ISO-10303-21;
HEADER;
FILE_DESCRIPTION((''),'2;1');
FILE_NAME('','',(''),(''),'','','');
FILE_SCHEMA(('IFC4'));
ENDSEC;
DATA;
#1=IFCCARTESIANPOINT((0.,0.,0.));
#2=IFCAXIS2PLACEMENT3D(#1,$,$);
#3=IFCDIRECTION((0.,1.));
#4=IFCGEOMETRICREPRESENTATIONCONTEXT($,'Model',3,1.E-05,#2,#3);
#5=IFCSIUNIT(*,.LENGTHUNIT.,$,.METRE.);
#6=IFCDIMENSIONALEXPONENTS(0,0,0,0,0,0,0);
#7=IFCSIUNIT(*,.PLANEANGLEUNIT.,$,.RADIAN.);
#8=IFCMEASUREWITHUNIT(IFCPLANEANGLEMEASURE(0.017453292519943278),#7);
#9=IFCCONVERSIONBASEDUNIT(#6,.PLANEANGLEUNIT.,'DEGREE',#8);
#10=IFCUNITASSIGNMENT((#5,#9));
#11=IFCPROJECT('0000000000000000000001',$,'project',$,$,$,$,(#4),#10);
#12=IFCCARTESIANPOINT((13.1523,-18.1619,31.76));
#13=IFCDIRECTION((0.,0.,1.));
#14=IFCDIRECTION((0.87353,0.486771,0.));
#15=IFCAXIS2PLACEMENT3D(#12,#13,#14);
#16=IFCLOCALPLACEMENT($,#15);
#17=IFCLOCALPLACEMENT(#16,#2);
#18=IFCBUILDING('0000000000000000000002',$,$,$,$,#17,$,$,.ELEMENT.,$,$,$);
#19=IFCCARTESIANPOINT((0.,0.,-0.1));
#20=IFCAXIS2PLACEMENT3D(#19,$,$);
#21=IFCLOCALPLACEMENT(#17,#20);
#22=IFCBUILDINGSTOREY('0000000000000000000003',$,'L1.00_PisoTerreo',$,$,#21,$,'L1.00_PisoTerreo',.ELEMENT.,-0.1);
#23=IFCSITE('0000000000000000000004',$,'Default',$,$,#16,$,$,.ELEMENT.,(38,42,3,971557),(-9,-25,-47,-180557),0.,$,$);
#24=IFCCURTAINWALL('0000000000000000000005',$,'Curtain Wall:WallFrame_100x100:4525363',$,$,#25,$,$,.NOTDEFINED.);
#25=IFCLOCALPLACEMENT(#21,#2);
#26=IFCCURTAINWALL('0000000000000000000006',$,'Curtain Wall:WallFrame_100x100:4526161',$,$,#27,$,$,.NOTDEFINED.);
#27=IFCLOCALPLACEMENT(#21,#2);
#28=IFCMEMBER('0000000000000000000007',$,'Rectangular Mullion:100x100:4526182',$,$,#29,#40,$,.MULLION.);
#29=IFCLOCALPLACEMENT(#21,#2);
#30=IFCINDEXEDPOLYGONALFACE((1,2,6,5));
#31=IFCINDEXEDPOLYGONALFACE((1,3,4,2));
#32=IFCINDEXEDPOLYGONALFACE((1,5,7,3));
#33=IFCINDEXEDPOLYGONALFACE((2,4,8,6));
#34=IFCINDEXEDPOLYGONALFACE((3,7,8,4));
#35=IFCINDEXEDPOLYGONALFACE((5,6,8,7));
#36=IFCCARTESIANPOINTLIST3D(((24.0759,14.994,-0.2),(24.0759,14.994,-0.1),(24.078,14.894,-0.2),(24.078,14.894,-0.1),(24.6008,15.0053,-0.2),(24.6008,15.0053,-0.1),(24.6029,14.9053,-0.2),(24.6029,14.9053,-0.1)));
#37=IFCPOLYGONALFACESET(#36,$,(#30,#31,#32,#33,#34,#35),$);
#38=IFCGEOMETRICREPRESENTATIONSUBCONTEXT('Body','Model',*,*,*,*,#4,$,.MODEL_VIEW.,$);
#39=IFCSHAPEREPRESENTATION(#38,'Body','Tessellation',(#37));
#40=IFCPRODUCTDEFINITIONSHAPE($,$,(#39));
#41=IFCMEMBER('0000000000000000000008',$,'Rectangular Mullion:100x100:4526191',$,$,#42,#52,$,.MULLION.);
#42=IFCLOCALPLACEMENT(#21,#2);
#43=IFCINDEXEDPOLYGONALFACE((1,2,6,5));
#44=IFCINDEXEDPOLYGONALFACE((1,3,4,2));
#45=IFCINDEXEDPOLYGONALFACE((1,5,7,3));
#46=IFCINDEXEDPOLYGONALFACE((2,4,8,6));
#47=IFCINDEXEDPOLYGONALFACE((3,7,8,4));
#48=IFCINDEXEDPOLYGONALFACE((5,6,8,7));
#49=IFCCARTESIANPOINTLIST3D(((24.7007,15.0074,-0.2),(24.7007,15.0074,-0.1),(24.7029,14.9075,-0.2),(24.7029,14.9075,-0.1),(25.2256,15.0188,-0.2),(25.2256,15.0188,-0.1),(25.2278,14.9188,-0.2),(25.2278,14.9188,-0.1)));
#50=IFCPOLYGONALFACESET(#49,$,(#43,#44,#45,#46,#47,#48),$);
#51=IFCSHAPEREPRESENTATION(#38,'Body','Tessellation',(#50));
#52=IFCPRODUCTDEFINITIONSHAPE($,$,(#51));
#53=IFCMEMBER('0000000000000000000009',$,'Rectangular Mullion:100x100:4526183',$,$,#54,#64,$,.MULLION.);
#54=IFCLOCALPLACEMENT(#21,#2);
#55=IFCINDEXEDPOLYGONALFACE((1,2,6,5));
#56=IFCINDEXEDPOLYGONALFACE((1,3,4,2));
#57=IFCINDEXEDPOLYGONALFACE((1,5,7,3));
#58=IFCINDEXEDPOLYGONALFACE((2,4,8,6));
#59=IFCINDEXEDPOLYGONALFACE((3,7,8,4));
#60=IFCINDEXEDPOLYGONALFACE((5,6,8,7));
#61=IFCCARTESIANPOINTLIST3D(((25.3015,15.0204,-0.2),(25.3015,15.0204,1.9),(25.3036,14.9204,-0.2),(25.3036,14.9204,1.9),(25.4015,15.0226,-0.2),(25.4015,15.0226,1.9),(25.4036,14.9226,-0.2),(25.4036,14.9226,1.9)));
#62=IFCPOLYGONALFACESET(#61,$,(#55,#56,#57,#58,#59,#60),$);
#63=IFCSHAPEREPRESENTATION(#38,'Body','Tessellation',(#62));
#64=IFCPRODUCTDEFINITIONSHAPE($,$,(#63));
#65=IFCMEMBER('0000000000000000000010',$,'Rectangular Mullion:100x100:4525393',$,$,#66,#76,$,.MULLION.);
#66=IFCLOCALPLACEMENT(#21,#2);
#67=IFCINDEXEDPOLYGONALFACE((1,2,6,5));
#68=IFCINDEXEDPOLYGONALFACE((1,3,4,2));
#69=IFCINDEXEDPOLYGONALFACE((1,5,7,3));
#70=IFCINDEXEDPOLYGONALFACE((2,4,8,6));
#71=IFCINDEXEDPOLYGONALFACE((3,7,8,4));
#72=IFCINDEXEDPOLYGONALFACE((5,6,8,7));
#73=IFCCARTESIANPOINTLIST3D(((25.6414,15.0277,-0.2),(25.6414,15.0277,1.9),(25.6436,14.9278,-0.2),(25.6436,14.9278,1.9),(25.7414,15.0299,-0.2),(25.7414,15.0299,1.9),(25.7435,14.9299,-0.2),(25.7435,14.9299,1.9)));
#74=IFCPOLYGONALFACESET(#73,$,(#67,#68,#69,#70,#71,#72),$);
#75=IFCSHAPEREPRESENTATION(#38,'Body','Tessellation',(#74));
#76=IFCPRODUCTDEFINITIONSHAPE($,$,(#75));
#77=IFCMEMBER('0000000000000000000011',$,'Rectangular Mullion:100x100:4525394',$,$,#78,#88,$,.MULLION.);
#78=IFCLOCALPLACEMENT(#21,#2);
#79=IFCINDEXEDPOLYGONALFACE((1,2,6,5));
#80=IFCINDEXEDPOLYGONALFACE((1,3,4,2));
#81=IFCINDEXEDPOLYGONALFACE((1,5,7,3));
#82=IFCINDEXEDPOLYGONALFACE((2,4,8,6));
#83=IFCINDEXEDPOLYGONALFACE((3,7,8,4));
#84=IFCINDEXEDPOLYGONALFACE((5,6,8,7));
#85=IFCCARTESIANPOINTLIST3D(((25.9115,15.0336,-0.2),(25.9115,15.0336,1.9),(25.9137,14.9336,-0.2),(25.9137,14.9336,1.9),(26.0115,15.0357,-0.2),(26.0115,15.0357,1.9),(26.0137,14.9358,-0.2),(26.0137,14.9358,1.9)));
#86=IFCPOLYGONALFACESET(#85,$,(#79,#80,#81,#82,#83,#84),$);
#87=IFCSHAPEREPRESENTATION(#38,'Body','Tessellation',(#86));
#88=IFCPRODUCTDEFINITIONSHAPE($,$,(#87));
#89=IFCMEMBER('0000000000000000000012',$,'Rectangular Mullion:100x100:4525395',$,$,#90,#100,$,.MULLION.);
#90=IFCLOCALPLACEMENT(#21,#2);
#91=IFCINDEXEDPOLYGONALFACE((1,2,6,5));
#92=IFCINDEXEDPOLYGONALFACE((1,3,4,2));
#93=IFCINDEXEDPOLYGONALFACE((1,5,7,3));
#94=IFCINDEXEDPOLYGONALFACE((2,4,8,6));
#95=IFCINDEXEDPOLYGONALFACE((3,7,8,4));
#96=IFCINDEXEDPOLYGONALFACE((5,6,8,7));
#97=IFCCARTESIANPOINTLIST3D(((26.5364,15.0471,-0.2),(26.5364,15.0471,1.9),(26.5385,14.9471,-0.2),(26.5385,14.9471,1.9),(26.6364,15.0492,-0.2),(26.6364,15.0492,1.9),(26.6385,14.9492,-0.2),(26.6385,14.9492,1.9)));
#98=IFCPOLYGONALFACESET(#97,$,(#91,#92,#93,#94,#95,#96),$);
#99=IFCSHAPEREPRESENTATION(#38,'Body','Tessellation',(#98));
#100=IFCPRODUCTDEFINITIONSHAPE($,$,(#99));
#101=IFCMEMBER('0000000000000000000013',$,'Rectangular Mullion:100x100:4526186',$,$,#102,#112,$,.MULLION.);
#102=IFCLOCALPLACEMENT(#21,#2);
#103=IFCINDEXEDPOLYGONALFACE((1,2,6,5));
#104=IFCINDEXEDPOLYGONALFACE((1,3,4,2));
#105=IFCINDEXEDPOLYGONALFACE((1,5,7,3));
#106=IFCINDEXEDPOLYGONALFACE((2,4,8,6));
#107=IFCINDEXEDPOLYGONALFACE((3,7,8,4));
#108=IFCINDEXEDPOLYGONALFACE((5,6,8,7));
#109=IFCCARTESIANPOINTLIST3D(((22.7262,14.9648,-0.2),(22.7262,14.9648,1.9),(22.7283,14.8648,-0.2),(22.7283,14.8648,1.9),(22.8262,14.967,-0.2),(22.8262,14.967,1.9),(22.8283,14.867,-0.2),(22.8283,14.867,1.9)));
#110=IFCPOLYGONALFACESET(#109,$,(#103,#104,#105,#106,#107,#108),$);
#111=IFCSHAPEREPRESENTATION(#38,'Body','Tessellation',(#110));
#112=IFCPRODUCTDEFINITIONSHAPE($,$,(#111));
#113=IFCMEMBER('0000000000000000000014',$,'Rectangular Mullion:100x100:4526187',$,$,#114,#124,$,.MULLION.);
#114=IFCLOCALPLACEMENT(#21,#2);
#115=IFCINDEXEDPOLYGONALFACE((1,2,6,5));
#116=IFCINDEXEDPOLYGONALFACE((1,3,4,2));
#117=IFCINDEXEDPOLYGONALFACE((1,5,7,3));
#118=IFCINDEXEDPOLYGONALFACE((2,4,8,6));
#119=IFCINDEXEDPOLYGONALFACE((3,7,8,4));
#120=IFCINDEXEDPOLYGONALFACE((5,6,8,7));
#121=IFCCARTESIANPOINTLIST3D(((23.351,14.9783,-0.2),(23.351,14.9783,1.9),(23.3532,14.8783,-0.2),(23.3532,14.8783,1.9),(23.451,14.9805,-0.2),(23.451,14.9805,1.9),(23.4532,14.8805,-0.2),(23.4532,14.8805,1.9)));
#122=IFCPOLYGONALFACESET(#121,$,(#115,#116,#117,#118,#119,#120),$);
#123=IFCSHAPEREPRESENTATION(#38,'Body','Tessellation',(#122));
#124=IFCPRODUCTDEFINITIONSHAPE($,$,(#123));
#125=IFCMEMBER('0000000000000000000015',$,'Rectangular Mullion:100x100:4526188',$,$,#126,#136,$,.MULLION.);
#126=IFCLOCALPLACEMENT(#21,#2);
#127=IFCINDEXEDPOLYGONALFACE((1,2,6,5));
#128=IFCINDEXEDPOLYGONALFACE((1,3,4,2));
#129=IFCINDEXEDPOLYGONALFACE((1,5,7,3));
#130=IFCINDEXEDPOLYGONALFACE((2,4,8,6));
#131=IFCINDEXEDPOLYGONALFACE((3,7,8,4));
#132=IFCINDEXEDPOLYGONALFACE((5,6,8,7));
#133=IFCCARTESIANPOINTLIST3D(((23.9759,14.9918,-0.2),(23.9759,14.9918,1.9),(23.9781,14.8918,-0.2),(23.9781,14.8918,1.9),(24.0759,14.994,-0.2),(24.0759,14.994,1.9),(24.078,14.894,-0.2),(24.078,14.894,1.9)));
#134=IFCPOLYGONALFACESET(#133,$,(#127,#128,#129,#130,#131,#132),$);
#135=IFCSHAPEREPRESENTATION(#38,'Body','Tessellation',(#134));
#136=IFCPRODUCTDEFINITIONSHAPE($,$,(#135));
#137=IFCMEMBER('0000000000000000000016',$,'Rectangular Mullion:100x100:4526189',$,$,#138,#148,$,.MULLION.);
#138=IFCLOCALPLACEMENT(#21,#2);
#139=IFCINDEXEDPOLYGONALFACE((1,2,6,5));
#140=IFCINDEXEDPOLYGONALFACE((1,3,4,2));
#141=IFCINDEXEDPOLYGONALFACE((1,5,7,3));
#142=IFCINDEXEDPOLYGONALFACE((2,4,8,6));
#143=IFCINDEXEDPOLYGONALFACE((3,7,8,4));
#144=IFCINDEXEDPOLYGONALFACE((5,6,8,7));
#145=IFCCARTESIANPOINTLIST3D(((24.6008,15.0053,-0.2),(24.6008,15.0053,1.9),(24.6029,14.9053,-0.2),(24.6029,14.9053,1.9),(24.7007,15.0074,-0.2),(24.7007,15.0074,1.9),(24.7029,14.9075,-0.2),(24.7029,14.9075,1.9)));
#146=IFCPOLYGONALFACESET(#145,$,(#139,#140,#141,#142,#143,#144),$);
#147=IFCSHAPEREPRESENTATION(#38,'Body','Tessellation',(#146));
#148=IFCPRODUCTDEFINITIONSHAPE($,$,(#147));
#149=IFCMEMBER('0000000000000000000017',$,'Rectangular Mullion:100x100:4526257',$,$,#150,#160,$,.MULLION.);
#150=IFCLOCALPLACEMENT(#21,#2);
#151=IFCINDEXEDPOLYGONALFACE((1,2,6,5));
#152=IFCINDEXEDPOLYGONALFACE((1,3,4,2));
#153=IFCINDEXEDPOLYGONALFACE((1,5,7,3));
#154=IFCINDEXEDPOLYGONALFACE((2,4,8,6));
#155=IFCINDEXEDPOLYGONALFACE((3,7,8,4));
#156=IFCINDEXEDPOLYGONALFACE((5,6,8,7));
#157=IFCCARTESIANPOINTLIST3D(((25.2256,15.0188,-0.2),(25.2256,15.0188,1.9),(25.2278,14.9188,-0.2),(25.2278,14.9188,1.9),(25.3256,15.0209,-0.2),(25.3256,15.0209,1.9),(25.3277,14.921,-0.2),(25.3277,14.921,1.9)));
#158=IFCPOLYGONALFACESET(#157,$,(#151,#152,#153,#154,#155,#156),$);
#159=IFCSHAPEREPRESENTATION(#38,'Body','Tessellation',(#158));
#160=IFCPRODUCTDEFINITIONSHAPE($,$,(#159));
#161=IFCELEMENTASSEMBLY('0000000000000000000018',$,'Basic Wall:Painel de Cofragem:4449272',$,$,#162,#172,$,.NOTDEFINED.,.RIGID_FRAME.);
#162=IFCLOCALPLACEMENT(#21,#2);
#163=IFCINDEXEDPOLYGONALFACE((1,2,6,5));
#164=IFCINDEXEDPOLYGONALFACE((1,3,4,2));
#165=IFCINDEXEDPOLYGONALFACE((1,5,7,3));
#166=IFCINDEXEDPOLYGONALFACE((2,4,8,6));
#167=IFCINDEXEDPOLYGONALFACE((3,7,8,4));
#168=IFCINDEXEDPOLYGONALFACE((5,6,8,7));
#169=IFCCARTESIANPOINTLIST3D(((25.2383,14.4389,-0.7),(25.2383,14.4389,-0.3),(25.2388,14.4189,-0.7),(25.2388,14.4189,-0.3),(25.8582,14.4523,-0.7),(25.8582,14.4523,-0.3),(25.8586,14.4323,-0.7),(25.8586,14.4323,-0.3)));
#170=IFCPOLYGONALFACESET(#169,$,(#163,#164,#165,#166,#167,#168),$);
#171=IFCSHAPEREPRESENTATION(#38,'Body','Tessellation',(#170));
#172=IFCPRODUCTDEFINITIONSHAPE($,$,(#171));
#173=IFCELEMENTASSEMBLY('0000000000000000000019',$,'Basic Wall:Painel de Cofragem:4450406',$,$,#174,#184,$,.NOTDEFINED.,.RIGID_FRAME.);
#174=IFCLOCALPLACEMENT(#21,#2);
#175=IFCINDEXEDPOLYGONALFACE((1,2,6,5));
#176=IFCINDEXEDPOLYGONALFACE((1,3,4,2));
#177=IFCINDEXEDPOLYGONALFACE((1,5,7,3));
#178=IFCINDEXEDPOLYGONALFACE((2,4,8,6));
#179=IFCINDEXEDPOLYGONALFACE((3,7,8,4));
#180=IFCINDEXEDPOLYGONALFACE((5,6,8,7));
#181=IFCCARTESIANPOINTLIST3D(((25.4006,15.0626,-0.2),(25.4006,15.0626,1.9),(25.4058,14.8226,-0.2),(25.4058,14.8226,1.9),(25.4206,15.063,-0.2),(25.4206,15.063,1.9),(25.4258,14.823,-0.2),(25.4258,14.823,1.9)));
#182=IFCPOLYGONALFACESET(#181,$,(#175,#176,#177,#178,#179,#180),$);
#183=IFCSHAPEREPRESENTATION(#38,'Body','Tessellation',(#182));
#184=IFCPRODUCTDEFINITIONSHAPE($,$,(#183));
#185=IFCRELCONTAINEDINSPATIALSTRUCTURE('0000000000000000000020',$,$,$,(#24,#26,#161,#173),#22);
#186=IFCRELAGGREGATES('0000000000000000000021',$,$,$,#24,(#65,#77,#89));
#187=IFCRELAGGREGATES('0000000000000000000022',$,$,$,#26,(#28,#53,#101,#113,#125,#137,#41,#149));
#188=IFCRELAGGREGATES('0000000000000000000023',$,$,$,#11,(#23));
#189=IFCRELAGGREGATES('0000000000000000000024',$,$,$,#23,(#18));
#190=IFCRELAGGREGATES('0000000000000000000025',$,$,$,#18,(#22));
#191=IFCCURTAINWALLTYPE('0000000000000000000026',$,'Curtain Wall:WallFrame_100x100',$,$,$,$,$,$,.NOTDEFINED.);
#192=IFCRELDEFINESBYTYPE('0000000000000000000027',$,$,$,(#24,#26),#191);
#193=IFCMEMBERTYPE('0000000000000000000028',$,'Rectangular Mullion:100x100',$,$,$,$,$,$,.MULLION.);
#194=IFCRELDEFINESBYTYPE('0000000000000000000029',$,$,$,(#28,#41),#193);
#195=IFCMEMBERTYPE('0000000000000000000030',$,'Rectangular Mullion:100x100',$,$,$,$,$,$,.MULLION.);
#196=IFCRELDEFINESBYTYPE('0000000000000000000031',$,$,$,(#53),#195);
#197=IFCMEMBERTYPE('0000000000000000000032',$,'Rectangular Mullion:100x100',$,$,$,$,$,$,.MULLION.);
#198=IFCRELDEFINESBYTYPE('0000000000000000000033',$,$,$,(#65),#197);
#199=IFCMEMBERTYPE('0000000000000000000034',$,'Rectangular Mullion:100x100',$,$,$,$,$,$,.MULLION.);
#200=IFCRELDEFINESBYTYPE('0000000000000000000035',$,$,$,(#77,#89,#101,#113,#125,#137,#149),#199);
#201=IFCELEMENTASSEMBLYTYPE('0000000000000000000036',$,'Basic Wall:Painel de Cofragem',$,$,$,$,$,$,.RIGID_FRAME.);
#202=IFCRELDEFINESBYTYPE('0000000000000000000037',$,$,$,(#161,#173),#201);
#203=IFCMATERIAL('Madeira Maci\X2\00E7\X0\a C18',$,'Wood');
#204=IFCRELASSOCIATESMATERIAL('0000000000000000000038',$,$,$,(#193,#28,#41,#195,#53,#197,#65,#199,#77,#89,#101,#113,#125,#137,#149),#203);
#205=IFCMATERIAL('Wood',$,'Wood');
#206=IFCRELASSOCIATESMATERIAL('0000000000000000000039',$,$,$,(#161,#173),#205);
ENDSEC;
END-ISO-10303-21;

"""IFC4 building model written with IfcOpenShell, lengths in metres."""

from ifc_helpers import new_model, entity, si_unit, converted_unit, direction, frame, origin, place, context, subcontext, project, spatial, indexed_curve, outline, extrude, source, transform, mapped, material, type_object, type_shapes, element, aggregate, save


model = new_model("IFC4")

# Units and contexts
model_context = context("Model", 3, precision=1e-05, world=origin(), true_north=direction((0.0, 1.0)))
body_context = subcontext(model_context, "Body", "Model", "MODEL_VIEW")
ifc_project = project(units=[si_unit("LENGTHUNIT", "METRE"), converted_unit("PLANEANGLEUNIT", "DEGREE", entity("IfcPlaneAngleMeasure", 0.017453292519943278), si_unit("PLANEANGLEUNIT", "RADIAN"), dimensions=[0, 0, 0, 0, 0, 0, 0])], contexts=[model_context])

# Site, building, storey
site_placement = place(None, frame((13.1523, -18.1619, 31.76), z_axis=(0.0, 0.0, 1.0), x_axis=(0.87353, 0.486771, 0.0)))
site = spatial("IfcSite", under=ifc_project, at=site_placement, Name="Default", CompositionType="ELEMENT", RefLatitude=(38, 42, 3, 971557), RefLongitude=(-9, -25, -47, -180557), RefElevation=0.0)
building_placement = place(site_placement, origin())
building = spatial("IfcBuilding", under=site, at=building_placement, CompositionType="ELEMENT")
storey_placement = place(building_placement, frame((0.0, 0.0, -0.1)))
storey = spatial("IfcBuildingStorey", under=building, at=storey_placement, Name="L1.00_PisoTerreo", LongName="L1.00_PisoTerreo", CompositionType="ELEMENT", Elevation=-0.1)

# Curtain walls
curtain_wall_type = type_object("IfcCurtainWallType", Name="Curtain Wall:WallFrame_100x100", PredefinedType="NOTDEFINED")
curtain_wall_1_placement = place(storey_placement, frame((0.0, 0.0, 0.1)))
curtain_wall_1 = element("IfcCurtainWall", 1, at=curtain_wall_1_placement, inside=storey, type_object=curtain_wall_type, Name="Curtain Wall:WallFrame_100x100:4525363", PredefinedType="NOTDEFINED")
ifc_material_1 = material(Name="Madeira Maciça C18", Category="Wood")
curtain_wall_2_placement = place(storey_placement, frame((0.0, 0.0, 0.1)))
curtain_wall_2 = element("IfcCurtainWall", 2, at=curtain_wall_2_placement, inside=storey, type_object=curtain_wall_type, Name="Curtain Wall:WallFrame_100x100:4526161", PredefinedType="NOTDEFINED")

# Members
member_type_1 = type_object("IfcMemberType", Name="Rectangular Mullion:100x100", PredefinedType="MULLION", material=ifc_material_1)
shared_shape_1 = source(origin(), body_context, "Body", "SweptSolid", [
    extrude(outline(indexed_curve([(-0.05, -0.05), (0.05, -0.05), (0.05, 0.05), (-0.05, 0.05), (-0.05, -0.05)], self_intersect=False)), frame((-0.05, 0.0, -0.525), z_axis=(0.0, 0.0, 1.0), x_axis=(0.0, -1.0, 0.0)), (0.0, 0.0, 1.0), 0.525),
])
type_shapes(member_type_1, [shared_shape_1])
member_1_placement = place(curtain_wall_2_placement, frame((24.077, 14.944, -0.3), z_axis=(-0.999767, -0.021581, 0.0), x_axis=(0.0, 0.0, -1.0)))
member_1 = element("IfcMember", 3, at=member_1_placement, type_object=member_type_1, material=ifc_material_1, Name="Rectangular Mullion:100x100:4526182", PredefinedType="MULLION", context=body_context, shape_type="MappedRepresentation", body=[
    mapped(shared_shape_1, transform((0.0, 0.0, 0.0), scale=1.0)),
])
member_2_placement = place(curtain_wall_2_placement, frame((24.7018, 14.9575, -0.3), z_axis=(-0.999767, -0.021581, 0.0), x_axis=(0.0, 0.0, -1.0)))
member_2 = element("IfcMember", 4, at=member_2_placement, type_object=member_type_1, material=ifc_material_1, Name="Rectangular Mullion:100x100:4526191", PredefinedType="MULLION", context=body_context, shape_type="MappedRepresentation", body=[
    mapped(shared_shape_1, transform((0.0, 0.0, 0.0), scale=1.0)),
])
member_type_2 = type_object("IfcMemberType", Name="Rectangular Mullion:100x100", PredefinedType="MULLION", material=ifc_material_1)
shared_shape_2 = source(origin(), body_context, "Body", "SweptSolid", [
    extrude(outline(indexed_curve([(-0.05, -0.05), (0.05, -0.05), (0.05, 0.05), (-0.05, 0.05), (-0.05, -0.05)], self_intersect=False)), frame((-0.05, 0.0, -2.1), z_axis=(0.0, 0.0, 1.0), x_axis=(-1.0, 0.0, 0.0)), (0.0, 0.0, 1.0), 2.1),
])
type_shapes(member_type_2, [shared_shape_2])
member_3_placement = place(curtain_wall_2_placement, frame((25.4025, 14.9726, -0.3), z_axis=(0.0, 0.0, -1.0), x_axis=(0.999767, 0.021581, 0.0)))
member_3 = element("IfcMember", 5, at=member_3_placement, type_object=member_type_2, material=ifc_material_1, Name="Rectangular Mullion:100x100:4526183", PredefinedType="MULLION", context=body_context, shape_type="MappedRepresentation", body=[
    mapped(shared_shape_2, transform((0.0, 0.0, 0.0), scale=1.0)),
])
member_type_3 = type_object("IfcMemberType", Name="Rectangular Mullion:100x100", PredefinedType="MULLION", material=ifc_material_1)
shared_shape_3 = source(origin(), body_context, "Body", "SweptSolid", [
    extrude(outline(indexed_curve([(-0.05, -0.05), (0.05, -0.05), (0.05, 0.05), (-0.05, 0.05), (-0.05, -0.05)], self_intersect=False)), frame((-0.05, 0.0, -2.1), z_axis=(0.0, 0.0, 1.0), x_axis=(0.0, -1.0, 0.0)), (0.0, 0.0, 1.0), 2.1),
])
type_shapes(member_type_3, [shared_shape_3])
member_4_placement = place(curtain_wall_1_placement, frame((25.6425, 14.9778, 1.8), z_axis=(0.0, 0.0, 1.0), x_axis=(-0.999767, -0.021581, 0.0)))
member_4 = element("IfcMember", 6, at=member_4_placement, type_object=member_type_3, material=ifc_material_1, Name="Rectangular Mullion:100x100:4525393", PredefinedType="MULLION", context=body_context, shape_type="MappedRepresentation", body=[
    mapped(shared_shape_3, transform((0.0, 0.0, 0.0), scale=1.0)),
])
member_type_4 = type_object("IfcMemberType", Name="Rectangular Mullion:100x100", PredefinedType="MULLION", material=ifc_material_1)
shared_shape_4 = source(origin(), body_context, "Body", "SweptSolid", [
    extrude(outline(indexed_curve([(-0.05, -0.05), (0.05, -0.05), (0.05, 0.05), (-0.05, 0.05), (-0.05, -0.05)], self_intersect=False)), frame((0.0, 0.0, -2.1), z_axis=(0.0, 0.0, 1.0), x_axis=(-1.0, 0.0, 0.0)), (0.0, 0.0, 1.0), 2.1),
])
type_shapes(member_type_4, [shared_shape_4])
member_5_placement = place(curtain_wall_1_placement, frame((25.9626, 14.9847, -0.3), z_axis=(0.0, 0.0, -1.0), x_axis=(0.999767, 0.021581, 0.0)))
member_5 = element("IfcMember", 7, at=member_5_placement, type_object=member_type_4, material=ifc_material_1, Name="Rectangular Mullion:100x100:4525394", PredefinedType="MULLION", context=body_context, shape_type="MappedRepresentation", body=[
    mapped(shared_shape_4, transform((0.0, 0.0, 0.0), scale=1.0)),
])
member_6_placement = place(curtain_wall_1_placement, frame((26.5874, 14.9982, -0.3), z_axis=(0.0, 0.0, -1.0), x_axis=(0.999767, 0.021581, 0.0)))
member_6 = element("IfcMember", 8, at=member_6_placement, type_object=member_type_4, material=ifc_material_1, Name="Rectangular Mullion:100x100:4525395", PredefinedType="MULLION", context=body_context, shape_type="MappedRepresentation", body=[
    mapped(shared_shape_4, transform((0.0, 0.0, 0.0), scale=1.0)),
])
aggregate(curtain_wall_1, [member_4, member_5, member_6])
member_7_placement = place(curtain_wall_2_placement, frame((22.7773, 14.9159, -0.3), z_axis=(0.0, 0.0, -1.0), x_axis=(0.999767, 0.021581, 0.0)))
member_7 = element("IfcMember", 9, at=member_7_placement, type_object=member_type_4, material=ifc_material_1, Name="Rectangular Mullion:100x100:4526186", PredefinedType="MULLION", context=body_context, shape_type="MappedRepresentation", body=[
    mapped(shared_shape_4, transform((0.0, 0.0, 0.0), scale=1.0)),
])
member_8_placement = place(curtain_wall_2_placement, frame((23.4021, 14.9294, -0.3), z_axis=(0.0, 0.0, -1.0), x_axis=(0.999767, 0.021581, 0.0)))
member_8 = element("IfcMember", 10, at=member_8_placement, type_object=member_type_4, material=ifc_material_1, Name="Rectangular Mullion:100x100:4526187", PredefinedType="MULLION", context=body_context, shape_type="MappedRepresentation", body=[
    mapped(shared_shape_4, transform((0.0, 0.0, 0.0), scale=1.0)),
])
member_9_placement = place(curtain_wall_2_placement, frame((24.027, 14.9429, -0.3), z_axis=(0.0, 0.0, -1.0), x_axis=(0.999767, 0.021581, 0.0)))
member_9 = element("IfcMember", 11, at=member_9_placement, type_object=member_type_4, material=ifc_material_1, Name="Rectangular Mullion:100x100:4526188", PredefinedType="MULLION", context=body_context, shape_type="MappedRepresentation", body=[
    mapped(shared_shape_4, transform((0.0, 0.0, 0.0), scale=1.0)),
])
member_10_placement = place(curtain_wall_2_placement, frame((24.6518, 14.9564, -0.3), z_axis=(0.0, 0.0, -1.0), x_axis=(0.999767, 0.021581, 0.0)))
member_10 = element("IfcMember", 12, at=member_10_placement, type_object=member_type_4, material=ifc_material_1, Name="Rectangular Mullion:100x100:4526189", PredefinedType="MULLION", context=body_context, shape_type="MappedRepresentation", body=[
    mapped(shared_shape_4, transform((0.0, 0.0, 0.0), scale=1.0)),
])
member_11_placement = place(curtain_wall_2_placement, frame((25.2767, 14.9699, -0.3), z_axis=(0.0, 0.0, -1.0), x_axis=(0.999767, 0.021581, 0.0)))
member_11 = element("IfcMember", 13, at=member_11_placement, type_object=member_type_4, material=ifc_material_1, Name="Rectangular Mullion:100x100:4526257", PredefinedType="MULLION", context=body_context, shape_type="MappedRepresentation", body=[
    mapped(shared_shape_4, transform((0.0, 0.0, 0.0), scale=1.0)),
])
aggregate(curtain_wall_2, [member_1, member_3, member_7, member_8, member_9, member_10, member_2, member_11])

# Element assemblies
ifc_material_2 = material(Name="Wood", Category="Wood")
element_assembly_type = type_object("IfcElementAssemblyType", Name="Basic Wall:Painel de Cofragem", PredefinedType="RIGID_FRAME")
assembly_1_placement = place(storey_placement, frame((25.2385, 14.4289, -0.7), z_axis=(0.0, 0.0, 1.0), x_axis=(0.999767, 0.021581, 0.0)))
element("IfcElementAssembly", 14, at=assembly_1_placement, inside=storey, type_object=element_assembly_type, material=ifc_material_2, Name="Basic Wall:Painel de Cofragem:4449272", AssemblyPlace="NOTDEFINED", PredefinedType="RIGID_FRAME", context=body_context, shape_type="SweptSolid", body=[
    extrude(outline(indexed_curve([(0.62, 0.01), (0.0, 0.01), (0.0, -0.01), (0.62, -0.01), (0.62, 0.01)], self_intersect=False)), origin(), (0.0, 0.0, 1.0), 0.4),
])
assembly_2_placement = place(storey_placement, frame((25.4106, 15.0628, -0.2), z_axis=(0.0, 0.0, 1.0), x_axis=(0.021581, -0.999767, 0.0)))
element("IfcElementAssembly", 15, at=assembly_2_placement, inside=storey, type_object=element_assembly_type, material=ifc_material_2, Name="Basic Wall:Painel de Cofragem:4450406", AssemblyPlace="NOTDEFINED", PredefinedType="RIGID_FRAME", context=body_context, shape_type="SweptSolid", body=[
    extrude(outline(indexed_curve([(0.24, 0.01), (0.0, 0.01), (0.0, -0.01), (0.24, -0.01), (0.24, 0.01)], self_intersect=False)), origin(), (0.0, 0.0, 1.0), 2.1),
])

save(model, "model.ifc")
